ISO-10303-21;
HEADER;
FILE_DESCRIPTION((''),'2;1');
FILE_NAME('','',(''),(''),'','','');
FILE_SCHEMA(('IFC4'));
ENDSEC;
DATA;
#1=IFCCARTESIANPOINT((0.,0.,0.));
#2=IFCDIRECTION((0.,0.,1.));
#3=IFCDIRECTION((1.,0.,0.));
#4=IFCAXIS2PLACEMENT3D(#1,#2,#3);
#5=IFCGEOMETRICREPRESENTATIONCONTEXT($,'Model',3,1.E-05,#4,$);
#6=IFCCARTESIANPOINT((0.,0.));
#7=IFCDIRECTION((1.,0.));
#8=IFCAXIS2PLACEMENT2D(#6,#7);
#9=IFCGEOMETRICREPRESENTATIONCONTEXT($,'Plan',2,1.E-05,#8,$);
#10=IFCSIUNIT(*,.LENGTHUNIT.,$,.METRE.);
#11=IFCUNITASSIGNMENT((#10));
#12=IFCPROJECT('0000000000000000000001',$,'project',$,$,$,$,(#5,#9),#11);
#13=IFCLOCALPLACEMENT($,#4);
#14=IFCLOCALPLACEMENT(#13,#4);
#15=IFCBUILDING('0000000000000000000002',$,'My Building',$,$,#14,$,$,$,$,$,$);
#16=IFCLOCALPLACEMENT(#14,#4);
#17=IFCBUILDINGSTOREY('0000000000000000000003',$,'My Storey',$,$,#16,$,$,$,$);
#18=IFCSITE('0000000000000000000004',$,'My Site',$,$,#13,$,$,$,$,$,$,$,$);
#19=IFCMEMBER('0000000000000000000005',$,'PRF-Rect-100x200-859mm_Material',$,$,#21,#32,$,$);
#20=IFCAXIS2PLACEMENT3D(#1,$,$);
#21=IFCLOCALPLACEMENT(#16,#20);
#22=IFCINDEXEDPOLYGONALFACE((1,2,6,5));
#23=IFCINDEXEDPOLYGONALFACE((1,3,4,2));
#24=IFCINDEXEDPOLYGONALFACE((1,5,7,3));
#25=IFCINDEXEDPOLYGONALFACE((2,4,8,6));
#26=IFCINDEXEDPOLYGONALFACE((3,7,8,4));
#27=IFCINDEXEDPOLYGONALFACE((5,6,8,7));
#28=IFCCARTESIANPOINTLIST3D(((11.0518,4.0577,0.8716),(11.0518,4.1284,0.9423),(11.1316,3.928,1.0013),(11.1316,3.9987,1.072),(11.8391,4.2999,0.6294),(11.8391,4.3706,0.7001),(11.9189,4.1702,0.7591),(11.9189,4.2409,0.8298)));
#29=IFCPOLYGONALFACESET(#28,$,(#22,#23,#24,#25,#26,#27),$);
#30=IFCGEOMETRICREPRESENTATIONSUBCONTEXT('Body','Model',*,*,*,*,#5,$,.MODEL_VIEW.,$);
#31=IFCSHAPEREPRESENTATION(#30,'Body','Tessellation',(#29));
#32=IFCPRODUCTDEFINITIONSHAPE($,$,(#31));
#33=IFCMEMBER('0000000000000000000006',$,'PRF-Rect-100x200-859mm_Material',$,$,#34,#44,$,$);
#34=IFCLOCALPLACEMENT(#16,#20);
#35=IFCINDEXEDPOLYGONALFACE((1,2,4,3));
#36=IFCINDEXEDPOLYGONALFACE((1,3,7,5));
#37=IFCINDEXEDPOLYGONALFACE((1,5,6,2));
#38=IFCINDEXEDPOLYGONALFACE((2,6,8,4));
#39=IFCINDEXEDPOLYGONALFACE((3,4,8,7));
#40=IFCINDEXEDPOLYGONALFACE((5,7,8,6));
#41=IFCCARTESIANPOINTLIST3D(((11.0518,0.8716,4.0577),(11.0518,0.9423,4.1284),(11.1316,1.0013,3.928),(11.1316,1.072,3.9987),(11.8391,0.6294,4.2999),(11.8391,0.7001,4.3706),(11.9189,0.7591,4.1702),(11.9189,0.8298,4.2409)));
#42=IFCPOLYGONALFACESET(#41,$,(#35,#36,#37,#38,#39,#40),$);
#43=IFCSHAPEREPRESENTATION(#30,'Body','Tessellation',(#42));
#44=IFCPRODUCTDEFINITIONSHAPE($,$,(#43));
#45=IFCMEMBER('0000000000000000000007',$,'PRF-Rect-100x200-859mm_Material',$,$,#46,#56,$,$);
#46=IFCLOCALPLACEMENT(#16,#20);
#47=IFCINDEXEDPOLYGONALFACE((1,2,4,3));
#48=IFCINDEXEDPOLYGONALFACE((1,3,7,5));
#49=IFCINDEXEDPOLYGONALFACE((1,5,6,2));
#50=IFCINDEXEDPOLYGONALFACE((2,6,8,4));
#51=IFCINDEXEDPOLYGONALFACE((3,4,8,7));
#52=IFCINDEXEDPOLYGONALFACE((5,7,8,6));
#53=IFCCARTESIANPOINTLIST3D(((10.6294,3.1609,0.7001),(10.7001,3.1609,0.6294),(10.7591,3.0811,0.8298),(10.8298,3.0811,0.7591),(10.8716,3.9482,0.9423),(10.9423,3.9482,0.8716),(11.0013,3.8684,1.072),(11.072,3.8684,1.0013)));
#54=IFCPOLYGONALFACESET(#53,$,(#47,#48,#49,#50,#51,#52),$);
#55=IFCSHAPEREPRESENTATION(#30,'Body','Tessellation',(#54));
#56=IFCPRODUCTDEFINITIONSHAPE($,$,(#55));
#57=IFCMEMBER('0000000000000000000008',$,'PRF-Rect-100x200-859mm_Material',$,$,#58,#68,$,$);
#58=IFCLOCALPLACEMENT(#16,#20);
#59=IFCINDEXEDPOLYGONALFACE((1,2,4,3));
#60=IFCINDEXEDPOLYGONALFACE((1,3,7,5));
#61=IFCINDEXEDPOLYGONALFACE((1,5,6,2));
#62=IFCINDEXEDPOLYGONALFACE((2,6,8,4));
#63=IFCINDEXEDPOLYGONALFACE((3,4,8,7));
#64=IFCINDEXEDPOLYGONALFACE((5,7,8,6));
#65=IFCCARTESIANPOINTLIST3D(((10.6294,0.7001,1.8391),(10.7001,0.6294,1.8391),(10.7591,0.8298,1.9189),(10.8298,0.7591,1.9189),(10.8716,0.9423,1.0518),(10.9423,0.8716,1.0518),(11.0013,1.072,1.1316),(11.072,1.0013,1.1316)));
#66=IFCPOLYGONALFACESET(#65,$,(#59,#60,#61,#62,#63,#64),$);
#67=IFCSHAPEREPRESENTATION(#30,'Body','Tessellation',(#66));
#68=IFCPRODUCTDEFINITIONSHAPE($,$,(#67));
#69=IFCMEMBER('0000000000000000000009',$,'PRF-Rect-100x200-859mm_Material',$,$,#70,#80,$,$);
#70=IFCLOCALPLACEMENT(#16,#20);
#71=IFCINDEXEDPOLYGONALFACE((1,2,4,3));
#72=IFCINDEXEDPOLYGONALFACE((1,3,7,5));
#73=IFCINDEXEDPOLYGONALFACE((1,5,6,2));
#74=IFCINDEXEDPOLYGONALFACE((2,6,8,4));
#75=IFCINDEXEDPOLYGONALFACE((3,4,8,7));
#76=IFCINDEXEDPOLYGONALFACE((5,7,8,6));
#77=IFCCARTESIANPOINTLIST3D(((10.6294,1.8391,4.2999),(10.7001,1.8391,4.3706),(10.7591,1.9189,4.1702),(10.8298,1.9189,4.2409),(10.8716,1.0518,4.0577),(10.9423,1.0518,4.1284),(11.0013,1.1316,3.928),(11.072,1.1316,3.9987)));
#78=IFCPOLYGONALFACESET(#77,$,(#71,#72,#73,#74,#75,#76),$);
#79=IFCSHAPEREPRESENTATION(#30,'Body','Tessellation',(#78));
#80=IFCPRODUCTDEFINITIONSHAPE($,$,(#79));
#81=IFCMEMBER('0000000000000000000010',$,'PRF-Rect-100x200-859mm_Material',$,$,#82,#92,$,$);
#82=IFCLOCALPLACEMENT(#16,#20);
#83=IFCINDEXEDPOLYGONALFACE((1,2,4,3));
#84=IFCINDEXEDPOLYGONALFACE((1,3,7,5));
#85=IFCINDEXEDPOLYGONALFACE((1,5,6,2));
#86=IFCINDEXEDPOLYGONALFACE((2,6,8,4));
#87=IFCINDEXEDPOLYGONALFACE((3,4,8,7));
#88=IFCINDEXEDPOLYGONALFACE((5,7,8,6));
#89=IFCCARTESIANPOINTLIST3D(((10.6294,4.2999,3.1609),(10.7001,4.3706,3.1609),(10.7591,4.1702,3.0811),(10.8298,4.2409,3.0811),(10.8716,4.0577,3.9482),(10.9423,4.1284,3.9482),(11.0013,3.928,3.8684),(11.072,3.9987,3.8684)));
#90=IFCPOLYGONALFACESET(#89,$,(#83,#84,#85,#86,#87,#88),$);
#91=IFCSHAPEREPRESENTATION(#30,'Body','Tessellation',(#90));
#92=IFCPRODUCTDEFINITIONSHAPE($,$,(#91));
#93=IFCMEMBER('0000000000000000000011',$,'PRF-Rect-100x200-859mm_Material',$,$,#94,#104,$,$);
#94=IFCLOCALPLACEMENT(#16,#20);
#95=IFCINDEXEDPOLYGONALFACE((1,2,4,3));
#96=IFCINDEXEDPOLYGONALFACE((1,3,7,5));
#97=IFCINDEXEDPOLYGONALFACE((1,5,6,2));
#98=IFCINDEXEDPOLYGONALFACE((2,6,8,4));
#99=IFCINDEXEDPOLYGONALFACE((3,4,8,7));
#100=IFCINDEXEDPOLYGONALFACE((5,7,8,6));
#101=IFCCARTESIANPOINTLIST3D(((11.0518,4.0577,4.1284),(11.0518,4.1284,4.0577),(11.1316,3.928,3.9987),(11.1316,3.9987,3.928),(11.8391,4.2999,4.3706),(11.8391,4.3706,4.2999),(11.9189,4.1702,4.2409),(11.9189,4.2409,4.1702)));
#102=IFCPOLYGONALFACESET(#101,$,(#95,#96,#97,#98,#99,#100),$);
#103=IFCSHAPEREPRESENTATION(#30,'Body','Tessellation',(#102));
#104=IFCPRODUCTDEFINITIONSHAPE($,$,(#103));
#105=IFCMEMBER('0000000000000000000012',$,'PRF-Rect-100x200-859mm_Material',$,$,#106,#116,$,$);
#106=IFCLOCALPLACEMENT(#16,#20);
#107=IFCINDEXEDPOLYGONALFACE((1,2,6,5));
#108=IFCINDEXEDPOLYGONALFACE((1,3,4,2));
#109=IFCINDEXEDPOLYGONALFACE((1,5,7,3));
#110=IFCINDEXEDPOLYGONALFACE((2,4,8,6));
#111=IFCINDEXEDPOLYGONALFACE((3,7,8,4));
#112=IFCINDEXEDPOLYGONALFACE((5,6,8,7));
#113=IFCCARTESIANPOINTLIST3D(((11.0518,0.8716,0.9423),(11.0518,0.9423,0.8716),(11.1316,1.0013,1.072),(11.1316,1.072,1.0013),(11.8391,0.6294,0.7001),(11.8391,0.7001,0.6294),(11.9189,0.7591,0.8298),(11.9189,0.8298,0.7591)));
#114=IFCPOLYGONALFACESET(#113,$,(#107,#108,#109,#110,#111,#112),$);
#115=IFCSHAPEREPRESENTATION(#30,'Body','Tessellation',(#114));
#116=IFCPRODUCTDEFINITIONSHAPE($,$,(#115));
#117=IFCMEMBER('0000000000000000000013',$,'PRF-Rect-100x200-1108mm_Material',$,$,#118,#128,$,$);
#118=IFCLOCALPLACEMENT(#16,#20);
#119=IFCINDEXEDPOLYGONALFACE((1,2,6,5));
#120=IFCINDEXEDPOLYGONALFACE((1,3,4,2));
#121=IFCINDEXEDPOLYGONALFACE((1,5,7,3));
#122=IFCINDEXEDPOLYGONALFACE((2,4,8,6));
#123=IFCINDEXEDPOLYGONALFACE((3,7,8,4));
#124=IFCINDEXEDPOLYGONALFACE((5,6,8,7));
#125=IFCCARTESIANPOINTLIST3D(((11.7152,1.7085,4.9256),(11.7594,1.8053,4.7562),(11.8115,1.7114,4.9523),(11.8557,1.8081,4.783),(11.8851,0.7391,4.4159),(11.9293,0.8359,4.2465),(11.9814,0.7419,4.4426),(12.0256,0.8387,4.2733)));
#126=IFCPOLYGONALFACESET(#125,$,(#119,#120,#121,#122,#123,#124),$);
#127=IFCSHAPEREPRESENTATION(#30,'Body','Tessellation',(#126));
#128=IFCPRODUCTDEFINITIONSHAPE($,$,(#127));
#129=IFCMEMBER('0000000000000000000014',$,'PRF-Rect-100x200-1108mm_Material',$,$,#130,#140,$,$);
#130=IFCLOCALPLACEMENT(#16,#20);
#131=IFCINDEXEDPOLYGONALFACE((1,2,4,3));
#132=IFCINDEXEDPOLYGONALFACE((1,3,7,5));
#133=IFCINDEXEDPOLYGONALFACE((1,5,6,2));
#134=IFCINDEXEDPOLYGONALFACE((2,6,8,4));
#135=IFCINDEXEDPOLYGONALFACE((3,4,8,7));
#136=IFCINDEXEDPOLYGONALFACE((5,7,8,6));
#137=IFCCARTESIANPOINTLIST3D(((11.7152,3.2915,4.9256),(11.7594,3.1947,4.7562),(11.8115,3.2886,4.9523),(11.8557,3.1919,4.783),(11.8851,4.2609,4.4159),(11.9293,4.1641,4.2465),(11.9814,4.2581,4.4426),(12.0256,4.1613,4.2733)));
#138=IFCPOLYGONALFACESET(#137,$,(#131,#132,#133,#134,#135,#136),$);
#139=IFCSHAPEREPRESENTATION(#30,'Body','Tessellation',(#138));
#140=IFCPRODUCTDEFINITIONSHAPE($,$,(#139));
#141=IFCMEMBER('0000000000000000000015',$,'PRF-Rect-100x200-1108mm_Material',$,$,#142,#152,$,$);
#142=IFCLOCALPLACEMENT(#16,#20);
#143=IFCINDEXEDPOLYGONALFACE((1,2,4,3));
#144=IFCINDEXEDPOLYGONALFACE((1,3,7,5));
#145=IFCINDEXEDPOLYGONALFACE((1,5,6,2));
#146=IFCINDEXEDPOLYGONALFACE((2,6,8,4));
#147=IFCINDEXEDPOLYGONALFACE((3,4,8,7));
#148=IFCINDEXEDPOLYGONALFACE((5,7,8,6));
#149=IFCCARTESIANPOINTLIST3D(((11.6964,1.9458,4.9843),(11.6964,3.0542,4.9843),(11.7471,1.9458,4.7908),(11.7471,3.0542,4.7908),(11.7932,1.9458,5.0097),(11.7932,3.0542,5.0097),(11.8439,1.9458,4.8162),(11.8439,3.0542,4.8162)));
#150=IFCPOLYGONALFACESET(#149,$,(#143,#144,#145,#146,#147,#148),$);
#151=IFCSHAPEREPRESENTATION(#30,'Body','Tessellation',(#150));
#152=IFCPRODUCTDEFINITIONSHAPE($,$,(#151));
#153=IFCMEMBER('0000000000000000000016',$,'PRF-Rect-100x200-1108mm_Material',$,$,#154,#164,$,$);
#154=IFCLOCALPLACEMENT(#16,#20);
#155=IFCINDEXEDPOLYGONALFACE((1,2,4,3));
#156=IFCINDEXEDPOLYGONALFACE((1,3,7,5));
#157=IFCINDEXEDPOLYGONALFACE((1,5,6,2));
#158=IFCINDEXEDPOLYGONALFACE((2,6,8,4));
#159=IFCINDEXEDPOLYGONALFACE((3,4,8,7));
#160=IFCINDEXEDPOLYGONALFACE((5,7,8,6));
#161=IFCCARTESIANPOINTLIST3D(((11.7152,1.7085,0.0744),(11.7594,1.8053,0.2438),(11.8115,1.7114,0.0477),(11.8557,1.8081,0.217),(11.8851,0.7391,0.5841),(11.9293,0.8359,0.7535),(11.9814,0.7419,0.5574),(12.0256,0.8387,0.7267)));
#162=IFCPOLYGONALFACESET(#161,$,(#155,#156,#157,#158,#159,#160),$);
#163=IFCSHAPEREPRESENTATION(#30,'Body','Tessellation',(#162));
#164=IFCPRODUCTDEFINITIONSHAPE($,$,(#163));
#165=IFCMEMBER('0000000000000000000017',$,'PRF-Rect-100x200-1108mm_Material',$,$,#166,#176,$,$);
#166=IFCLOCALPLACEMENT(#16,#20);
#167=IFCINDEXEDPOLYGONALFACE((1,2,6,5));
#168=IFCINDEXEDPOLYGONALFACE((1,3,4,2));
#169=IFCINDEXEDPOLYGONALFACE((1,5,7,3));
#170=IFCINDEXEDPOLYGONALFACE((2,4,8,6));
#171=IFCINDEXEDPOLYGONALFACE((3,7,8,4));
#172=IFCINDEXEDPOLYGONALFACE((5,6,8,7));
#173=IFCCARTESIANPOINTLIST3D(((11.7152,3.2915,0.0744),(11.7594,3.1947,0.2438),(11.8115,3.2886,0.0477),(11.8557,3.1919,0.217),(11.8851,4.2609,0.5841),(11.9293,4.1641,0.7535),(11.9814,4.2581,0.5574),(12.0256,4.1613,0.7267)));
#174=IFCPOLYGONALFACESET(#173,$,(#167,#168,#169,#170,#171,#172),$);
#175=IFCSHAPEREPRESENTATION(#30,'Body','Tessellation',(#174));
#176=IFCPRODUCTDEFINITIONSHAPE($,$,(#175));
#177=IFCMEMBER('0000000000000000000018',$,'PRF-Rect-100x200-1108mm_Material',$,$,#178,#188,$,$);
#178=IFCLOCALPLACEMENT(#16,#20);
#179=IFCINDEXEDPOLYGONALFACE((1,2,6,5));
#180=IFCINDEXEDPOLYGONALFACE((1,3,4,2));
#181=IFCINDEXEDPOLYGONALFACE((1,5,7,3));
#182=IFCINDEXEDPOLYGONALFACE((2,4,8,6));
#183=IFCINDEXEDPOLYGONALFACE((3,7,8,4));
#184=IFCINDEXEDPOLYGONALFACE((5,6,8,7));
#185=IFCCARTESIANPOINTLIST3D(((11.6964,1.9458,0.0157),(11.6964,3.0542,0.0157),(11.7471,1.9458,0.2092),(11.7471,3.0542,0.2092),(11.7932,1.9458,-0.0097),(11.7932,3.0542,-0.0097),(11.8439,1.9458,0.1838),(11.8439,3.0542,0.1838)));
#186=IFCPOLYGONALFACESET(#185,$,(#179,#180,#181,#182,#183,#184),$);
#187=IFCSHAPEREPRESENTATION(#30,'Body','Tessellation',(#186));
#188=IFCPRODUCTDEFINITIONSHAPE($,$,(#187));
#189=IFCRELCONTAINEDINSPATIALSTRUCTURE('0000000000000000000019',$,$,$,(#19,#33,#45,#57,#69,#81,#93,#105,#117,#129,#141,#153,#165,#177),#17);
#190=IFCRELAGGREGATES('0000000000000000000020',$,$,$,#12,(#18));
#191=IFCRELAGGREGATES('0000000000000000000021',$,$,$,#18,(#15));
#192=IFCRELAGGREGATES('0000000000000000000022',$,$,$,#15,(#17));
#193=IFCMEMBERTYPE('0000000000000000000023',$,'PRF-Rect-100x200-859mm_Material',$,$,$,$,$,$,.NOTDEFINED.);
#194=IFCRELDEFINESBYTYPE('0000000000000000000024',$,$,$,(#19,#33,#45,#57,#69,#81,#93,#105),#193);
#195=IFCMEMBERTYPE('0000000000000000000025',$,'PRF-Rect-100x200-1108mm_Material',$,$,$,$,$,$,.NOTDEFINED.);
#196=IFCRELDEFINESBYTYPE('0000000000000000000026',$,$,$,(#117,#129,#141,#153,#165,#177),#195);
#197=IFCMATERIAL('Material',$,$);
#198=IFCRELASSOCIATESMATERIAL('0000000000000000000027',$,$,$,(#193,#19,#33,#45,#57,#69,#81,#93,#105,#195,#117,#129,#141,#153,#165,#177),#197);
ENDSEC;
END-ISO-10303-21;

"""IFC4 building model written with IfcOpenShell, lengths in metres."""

from ifc_helpers import new_model, si_unit, frame, origin, origin_with_axes, origin_2d_with_axis, place, context, subcontext, project, spatial, rectangle, extrude, material, material_profile, profile_set, profile_usage, type_object, element, save


model = new_model("IFC4")

# Units and contexts
model_context = context("Model", 3, precision=1e-05, world=origin_with_axes())
plan_context = context("Plan", 2, precision=1e-05, world=origin_2d_with_axis())
body_context = subcontext(model_context, "Body", "Model", "MODEL_VIEW")
ifc_project = project(units=[si_unit("LENGTHUNIT", "METRE")], contexts=[model_context, plan_context])

# Site, building, storey
site_placement = place(None, origin_with_axes())
site = spatial("IfcSite", under=ifc_project, at=site_placement, Name="My Site")
building_placement = place(site_placement, origin_with_axes())
building = spatial("IfcBuilding", under=site, at=building_placement, Name="My Building")
storey_placement = place(building_placement, origin_with_axes())
storey = spatial("IfcBuildingStorey", under=building, at=storey_placement, Name="My Storey")

# Members
ifc_material = material(Name="Material")
ifc_material_profile_1 = material_profile(ifc_material, rectangle(XDim=0.1, YDim=0.2))
ifc_profile_set_1 = profile_set([ifc_material_profile_1], Name="PRF-Rect-100x200-859mm_Material")
ifc_profile_usage_1 = profile_usage(ifc_profile_set_1, cardinal=5)
member_type_1 = type_object("IfcMemberType", Name="PRF-Rect-100x200-859mm_Material", PredefinedType="NOTDEFINED", material=ifc_profile_set_1)
member_1_placement = place(storey_placement, frame((11.879, 4.2704, 0.7296), z_axis=(-0.916994, -0.282066, 0.282066), x_axis=(0.0, 0.707107, 0.707107)))
element("IfcMember", 1, at=member_1_placement, inside=storey, type_object=member_type_1, material=ifc_profile_usage_1, Name="PRF-Rect-100x200-859mm_Material", context=body_context, shape_type="SweptSolid", body=[
    extrude(rectangle(XDim=0.1, YDim=0.2), origin(), (0.0, 0.0, 1.0), 0.8586),
])
ifc_profile_usage_2 = profile_usage(ifc_profile_set_1, cardinal=5)
member_2_placement = place(storey_placement, frame((11.879, 0.7296, 4.2704), z_axis=(-0.916993, 0.282067, -0.282066), x_axis=(0.0, -0.707107, -0.707107)))
element("IfcMember", 2, at=member_2_placement, inside=storey, type_object=member_type_1, material=ifc_profile_usage_2, Name="PRF-Rect-100x200-859mm_Material", context=body_context, shape_type="SweptSolid", body=[
    extrude(rectangle(XDim=0.1, YDim=0.2), origin(), (0.0, 0.0, 1.0), 0.8586),
])
ifc_profile_usage_3 = profile_usage(ifc_profile_set_1, cardinal=5)
member_3_placement = place(storey_placement, frame((10.9718, 3.9083, 0.9718), z_axis=(-0.282066, -0.916993, -0.282066), x_axis=(-0.707107, 0.0, 0.707107)))
element("IfcMember", 3, at=member_3_placement, inside=storey, type_object=member_type_1, material=ifc_profile_usage_3, Name="PRF-Rect-100x200-859mm_Material", context=body_context, shape_type="SweptSolid", body=[
    extrude(rectangle(XDim=0.1, YDim=0.2), origin(), (0.0, 0.0, 1.0), 0.8586),
])
ifc_profile_usage_4 = profile_usage(ifc_profile_set_1, cardinal=5)
member_4_placement = place(storey_placement, frame((10.9718, 0.9718, 1.0917), z_axis=(-0.282066, -0.282067, 0.916993), x_axis=(-0.707107, 0.707107, 0.0)))
element("IfcMember", 4, at=member_4_placement, inside=storey, type_object=member_type_1, material=ifc_profile_usage_4, Name="PRF-Rect-100x200-859mm_Material", context=body_context, shape_type="SweptSolid", body=[
    extrude(rectangle(XDim=0.1, YDim=0.2), origin(), (0.0, 0.0, 1.0), 0.8586),
])
ifc_profile_usage_5 = profile_usage(ifc_profile_set_1, cardinal=5)
member_5_placement = place(storey_placement, frame((10.9718, 1.0917, 4.0282), z_axis=(-0.282066, 0.916994, 0.282066), x_axis=(-0.707107, 0.0, -0.707107)))
element("IfcMember", 5, at=member_5_placement, inside=storey, type_object=member_type_1, material=ifc_profile_usage_5, Name="PRF-Rect-100x200-859mm_Material", context=body_context, shape_type="SweptSolid", body=[
    extrude(rectangle(XDim=0.1, YDim=0.2), origin(), (0.0, 0.0, 1.0), 0.8586),
])
ifc_profile_usage_6 = profile_usage(ifc_profile_set_1, cardinal=5)
member_6_placement = place(storey_placement, frame((10.9718, 4.0282, 3.9083), z_axis=(-0.282066, 0.282066, -0.916994), x_axis=(-0.707107, -0.707107, 0.0)))
element("IfcMember", 6, at=member_6_placement, inside=storey, type_object=member_type_1, material=ifc_profile_usage_6, Name="PRF-Rect-100x200-859mm_Material", context=body_context, shape_type="SweptSolid", body=[
    extrude(rectangle(XDim=0.1, YDim=0.2), origin(), (0.0, 0.0, 1.0), 0.8586),
])
ifc_profile_usage_7 = profile_usage(ifc_profile_set_1, cardinal=5)
member_7_placement = place(storey_placement, frame((11.0917, 4.0282, 4.0282), z_axis=(0.916994, 0.282066, 0.282066), x_axis=(0.0, 0.707107, -0.707107)))
element("IfcMember", 7, at=member_7_placement, inside=storey, type_object=member_type_1, material=ifc_profile_usage_7, Name="PRF-Rect-100x200-859mm_Material", context=body_context, shape_type="SweptSolid", body=[
    extrude(rectangle(XDim=0.1, YDim=0.2), origin(), (0.0, 0.0, 1.0), 0.8586),
])
ifc_profile_usage_8 = profile_usage(ifc_profile_set_1, cardinal=5)
member_8_placement = place(storey_placement, frame((11.0917, 0.9718, 0.9718), z_axis=(0.916993, -0.282066, -0.282066), x_axis=(0.0, -0.707107, 0.707107)))
element("IfcMember", 8, at=member_8_placement, inside=storey, type_object=member_type_1, material=ifc_profile_usage_8, Name="PRF-Rect-100x200-859mm_Material", context=body_context, shape_type="SweptSolid", body=[
    extrude(rectangle(XDim=0.1, YDim=0.2), origin(), (0.0, 0.0, 1.0), 0.8586),
])
ifc_material_profile_2 = material_profile(ifc_material, rectangle(XDim=0.1, YDim=0.2))
ifc_profile_set_2 = profile_set([ifc_material_profile_2], Name="PRF-Rect-100x200-1108mm_Material")
ifc_profile_usage_9 = profile_usage(ifc_profile_set_2, cardinal=5)
member_type_2 = type_object("IfcMemberType", Name="PRF-Rect-100x200-1108mm_Material", PredefinedType="NOTDEFINED", material=ifc_profile_set_2)
member_9_placement = place(storey_placement, frame((11.7855, 1.7583, 4.8543), z_axis=(0.153283, -0.874667, -0.459849), x_axis=(0.963147, 0.028153, 0.2675)))
element("IfcMember", 9, at=member_9_placement, inside=storey, type_object=member_type_2, material=ifc_profile_usage_9, Name="PRF-Rect-100x200-1108mm_Material", context=body_context, shape_type="SweptSolid", body=[
    extrude(rectangle(XDim=0.1, YDim=0.2), origin(), (0.0, 0.0, 1.0), 1.1084),
])
ifc_profile_usage_10 = profile_usage(ifc_profile_set_2, cardinal=5)
member_10_placement = place(storey_placement, frame((11.9554, 4.2111, 4.3446), z_axis=(-0.153283, -0.874668, 0.459849), x_axis=(0.963147, -0.028153, 0.2675)))
element("IfcMember", 10, at=member_10_placement, inside=storey, type_object=member_type_2, material=ifc_profile_usage_10, Name="PRF-Rect-100x200-1108mm_Material", context=body_context, shape_type="SweptSolid", body=[
    extrude(rectangle(XDim=0.1, YDim=0.2), origin(), (0.0, 0.0, 1.0), 1.1084),
])
ifc_profile_usage_11 = profile_usage(ifc_profile_set_2, cardinal=5)
member_11_placement = place(storey_placement, frame((11.7702, 3.0542, 4.9002), z_axis=(0.0, -1.0, 0.0), x_axis=(0.967317, 0.0, 0.253569)))
element("IfcMember", 11, at=member_11_placement, inside=storey, type_object=member_type_2, material=ifc_profile_usage_11, Name="PRF-Rect-100x200-1108mm_Material", context=body_context, shape_type="SweptSolid", body=[
    extrude(rectangle(XDim=0.1, YDim=0.2), origin(), (0.0, 0.0, 1.0), 1.1084),
])
ifc_profile_usage_12 = profile_usage(ifc_profile_set_2, cardinal=5)
member_12_placement = place(storey_placement, frame((11.7855, 1.7583, 0.1457), z_axis=(0.153283, -0.874667, 0.459849), x_axis=(-0.963147, -0.028153, 0.2675)))
element("IfcMember", 12, at=member_12_placement, inside=storey, type_object=member_type_2, material=ifc_profile_usage_12, Name="PRF-Rect-100x200-1108mm_Material", context=body_context, shape_type="SweptSolid", body=[
    extrude(rectangle(XDim=0.1, YDim=0.2), origin(), (0.0, 0.0, 1.0), 1.1084),
])
ifc_profile_usage_13 = profile_usage(ifc_profile_set_2, cardinal=5)
member_13_placement = place(storey_placement, frame((11.9554, 4.2111, 0.6554), z_axis=(-0.153283, -0.874668, -0.459849), x_axis=(-0.963147, 0.028153, 0.2675)))
element("IfcMember", 13, at=member_13_placement, inside=storey, type_object=member_type_2, material=ifc_profile_usage_13, Name="PRF-Rect-100x200-1108mm_Material", context=body_context, shape_type="SweptSolid", body=[
    extrude(rectangle(XDim=0.1, YDim=0.2), origin(), (0.0, 0.0, 1.0), 1.1084),
])
ifc_profile_usage_14 = profile_usage(ifc_profile_set_2, cardinal=5)
member_14_placement = place(storey_placement, frame((11.7702, 3.0542, 0.0998), z_axis=(0.0, -1.0, 0.0), x_axis=(-0.967317, 0.0, 0.253569)))
element("IfcMember", 14, at=member_14_placement, inside=storey, type_object=member_type_2, material=ifc_profile_usage_14, Name="PRF-Rect-100x200-1108mm_Material", context=body_context, shape_type="SweptSolid", body=[
    extrude(rectangle(XDim=0.1, YDim=0.2), origin(), (0.0, 0.0, 1.0), 1.1084),
])

save(model, "model.ifc")
